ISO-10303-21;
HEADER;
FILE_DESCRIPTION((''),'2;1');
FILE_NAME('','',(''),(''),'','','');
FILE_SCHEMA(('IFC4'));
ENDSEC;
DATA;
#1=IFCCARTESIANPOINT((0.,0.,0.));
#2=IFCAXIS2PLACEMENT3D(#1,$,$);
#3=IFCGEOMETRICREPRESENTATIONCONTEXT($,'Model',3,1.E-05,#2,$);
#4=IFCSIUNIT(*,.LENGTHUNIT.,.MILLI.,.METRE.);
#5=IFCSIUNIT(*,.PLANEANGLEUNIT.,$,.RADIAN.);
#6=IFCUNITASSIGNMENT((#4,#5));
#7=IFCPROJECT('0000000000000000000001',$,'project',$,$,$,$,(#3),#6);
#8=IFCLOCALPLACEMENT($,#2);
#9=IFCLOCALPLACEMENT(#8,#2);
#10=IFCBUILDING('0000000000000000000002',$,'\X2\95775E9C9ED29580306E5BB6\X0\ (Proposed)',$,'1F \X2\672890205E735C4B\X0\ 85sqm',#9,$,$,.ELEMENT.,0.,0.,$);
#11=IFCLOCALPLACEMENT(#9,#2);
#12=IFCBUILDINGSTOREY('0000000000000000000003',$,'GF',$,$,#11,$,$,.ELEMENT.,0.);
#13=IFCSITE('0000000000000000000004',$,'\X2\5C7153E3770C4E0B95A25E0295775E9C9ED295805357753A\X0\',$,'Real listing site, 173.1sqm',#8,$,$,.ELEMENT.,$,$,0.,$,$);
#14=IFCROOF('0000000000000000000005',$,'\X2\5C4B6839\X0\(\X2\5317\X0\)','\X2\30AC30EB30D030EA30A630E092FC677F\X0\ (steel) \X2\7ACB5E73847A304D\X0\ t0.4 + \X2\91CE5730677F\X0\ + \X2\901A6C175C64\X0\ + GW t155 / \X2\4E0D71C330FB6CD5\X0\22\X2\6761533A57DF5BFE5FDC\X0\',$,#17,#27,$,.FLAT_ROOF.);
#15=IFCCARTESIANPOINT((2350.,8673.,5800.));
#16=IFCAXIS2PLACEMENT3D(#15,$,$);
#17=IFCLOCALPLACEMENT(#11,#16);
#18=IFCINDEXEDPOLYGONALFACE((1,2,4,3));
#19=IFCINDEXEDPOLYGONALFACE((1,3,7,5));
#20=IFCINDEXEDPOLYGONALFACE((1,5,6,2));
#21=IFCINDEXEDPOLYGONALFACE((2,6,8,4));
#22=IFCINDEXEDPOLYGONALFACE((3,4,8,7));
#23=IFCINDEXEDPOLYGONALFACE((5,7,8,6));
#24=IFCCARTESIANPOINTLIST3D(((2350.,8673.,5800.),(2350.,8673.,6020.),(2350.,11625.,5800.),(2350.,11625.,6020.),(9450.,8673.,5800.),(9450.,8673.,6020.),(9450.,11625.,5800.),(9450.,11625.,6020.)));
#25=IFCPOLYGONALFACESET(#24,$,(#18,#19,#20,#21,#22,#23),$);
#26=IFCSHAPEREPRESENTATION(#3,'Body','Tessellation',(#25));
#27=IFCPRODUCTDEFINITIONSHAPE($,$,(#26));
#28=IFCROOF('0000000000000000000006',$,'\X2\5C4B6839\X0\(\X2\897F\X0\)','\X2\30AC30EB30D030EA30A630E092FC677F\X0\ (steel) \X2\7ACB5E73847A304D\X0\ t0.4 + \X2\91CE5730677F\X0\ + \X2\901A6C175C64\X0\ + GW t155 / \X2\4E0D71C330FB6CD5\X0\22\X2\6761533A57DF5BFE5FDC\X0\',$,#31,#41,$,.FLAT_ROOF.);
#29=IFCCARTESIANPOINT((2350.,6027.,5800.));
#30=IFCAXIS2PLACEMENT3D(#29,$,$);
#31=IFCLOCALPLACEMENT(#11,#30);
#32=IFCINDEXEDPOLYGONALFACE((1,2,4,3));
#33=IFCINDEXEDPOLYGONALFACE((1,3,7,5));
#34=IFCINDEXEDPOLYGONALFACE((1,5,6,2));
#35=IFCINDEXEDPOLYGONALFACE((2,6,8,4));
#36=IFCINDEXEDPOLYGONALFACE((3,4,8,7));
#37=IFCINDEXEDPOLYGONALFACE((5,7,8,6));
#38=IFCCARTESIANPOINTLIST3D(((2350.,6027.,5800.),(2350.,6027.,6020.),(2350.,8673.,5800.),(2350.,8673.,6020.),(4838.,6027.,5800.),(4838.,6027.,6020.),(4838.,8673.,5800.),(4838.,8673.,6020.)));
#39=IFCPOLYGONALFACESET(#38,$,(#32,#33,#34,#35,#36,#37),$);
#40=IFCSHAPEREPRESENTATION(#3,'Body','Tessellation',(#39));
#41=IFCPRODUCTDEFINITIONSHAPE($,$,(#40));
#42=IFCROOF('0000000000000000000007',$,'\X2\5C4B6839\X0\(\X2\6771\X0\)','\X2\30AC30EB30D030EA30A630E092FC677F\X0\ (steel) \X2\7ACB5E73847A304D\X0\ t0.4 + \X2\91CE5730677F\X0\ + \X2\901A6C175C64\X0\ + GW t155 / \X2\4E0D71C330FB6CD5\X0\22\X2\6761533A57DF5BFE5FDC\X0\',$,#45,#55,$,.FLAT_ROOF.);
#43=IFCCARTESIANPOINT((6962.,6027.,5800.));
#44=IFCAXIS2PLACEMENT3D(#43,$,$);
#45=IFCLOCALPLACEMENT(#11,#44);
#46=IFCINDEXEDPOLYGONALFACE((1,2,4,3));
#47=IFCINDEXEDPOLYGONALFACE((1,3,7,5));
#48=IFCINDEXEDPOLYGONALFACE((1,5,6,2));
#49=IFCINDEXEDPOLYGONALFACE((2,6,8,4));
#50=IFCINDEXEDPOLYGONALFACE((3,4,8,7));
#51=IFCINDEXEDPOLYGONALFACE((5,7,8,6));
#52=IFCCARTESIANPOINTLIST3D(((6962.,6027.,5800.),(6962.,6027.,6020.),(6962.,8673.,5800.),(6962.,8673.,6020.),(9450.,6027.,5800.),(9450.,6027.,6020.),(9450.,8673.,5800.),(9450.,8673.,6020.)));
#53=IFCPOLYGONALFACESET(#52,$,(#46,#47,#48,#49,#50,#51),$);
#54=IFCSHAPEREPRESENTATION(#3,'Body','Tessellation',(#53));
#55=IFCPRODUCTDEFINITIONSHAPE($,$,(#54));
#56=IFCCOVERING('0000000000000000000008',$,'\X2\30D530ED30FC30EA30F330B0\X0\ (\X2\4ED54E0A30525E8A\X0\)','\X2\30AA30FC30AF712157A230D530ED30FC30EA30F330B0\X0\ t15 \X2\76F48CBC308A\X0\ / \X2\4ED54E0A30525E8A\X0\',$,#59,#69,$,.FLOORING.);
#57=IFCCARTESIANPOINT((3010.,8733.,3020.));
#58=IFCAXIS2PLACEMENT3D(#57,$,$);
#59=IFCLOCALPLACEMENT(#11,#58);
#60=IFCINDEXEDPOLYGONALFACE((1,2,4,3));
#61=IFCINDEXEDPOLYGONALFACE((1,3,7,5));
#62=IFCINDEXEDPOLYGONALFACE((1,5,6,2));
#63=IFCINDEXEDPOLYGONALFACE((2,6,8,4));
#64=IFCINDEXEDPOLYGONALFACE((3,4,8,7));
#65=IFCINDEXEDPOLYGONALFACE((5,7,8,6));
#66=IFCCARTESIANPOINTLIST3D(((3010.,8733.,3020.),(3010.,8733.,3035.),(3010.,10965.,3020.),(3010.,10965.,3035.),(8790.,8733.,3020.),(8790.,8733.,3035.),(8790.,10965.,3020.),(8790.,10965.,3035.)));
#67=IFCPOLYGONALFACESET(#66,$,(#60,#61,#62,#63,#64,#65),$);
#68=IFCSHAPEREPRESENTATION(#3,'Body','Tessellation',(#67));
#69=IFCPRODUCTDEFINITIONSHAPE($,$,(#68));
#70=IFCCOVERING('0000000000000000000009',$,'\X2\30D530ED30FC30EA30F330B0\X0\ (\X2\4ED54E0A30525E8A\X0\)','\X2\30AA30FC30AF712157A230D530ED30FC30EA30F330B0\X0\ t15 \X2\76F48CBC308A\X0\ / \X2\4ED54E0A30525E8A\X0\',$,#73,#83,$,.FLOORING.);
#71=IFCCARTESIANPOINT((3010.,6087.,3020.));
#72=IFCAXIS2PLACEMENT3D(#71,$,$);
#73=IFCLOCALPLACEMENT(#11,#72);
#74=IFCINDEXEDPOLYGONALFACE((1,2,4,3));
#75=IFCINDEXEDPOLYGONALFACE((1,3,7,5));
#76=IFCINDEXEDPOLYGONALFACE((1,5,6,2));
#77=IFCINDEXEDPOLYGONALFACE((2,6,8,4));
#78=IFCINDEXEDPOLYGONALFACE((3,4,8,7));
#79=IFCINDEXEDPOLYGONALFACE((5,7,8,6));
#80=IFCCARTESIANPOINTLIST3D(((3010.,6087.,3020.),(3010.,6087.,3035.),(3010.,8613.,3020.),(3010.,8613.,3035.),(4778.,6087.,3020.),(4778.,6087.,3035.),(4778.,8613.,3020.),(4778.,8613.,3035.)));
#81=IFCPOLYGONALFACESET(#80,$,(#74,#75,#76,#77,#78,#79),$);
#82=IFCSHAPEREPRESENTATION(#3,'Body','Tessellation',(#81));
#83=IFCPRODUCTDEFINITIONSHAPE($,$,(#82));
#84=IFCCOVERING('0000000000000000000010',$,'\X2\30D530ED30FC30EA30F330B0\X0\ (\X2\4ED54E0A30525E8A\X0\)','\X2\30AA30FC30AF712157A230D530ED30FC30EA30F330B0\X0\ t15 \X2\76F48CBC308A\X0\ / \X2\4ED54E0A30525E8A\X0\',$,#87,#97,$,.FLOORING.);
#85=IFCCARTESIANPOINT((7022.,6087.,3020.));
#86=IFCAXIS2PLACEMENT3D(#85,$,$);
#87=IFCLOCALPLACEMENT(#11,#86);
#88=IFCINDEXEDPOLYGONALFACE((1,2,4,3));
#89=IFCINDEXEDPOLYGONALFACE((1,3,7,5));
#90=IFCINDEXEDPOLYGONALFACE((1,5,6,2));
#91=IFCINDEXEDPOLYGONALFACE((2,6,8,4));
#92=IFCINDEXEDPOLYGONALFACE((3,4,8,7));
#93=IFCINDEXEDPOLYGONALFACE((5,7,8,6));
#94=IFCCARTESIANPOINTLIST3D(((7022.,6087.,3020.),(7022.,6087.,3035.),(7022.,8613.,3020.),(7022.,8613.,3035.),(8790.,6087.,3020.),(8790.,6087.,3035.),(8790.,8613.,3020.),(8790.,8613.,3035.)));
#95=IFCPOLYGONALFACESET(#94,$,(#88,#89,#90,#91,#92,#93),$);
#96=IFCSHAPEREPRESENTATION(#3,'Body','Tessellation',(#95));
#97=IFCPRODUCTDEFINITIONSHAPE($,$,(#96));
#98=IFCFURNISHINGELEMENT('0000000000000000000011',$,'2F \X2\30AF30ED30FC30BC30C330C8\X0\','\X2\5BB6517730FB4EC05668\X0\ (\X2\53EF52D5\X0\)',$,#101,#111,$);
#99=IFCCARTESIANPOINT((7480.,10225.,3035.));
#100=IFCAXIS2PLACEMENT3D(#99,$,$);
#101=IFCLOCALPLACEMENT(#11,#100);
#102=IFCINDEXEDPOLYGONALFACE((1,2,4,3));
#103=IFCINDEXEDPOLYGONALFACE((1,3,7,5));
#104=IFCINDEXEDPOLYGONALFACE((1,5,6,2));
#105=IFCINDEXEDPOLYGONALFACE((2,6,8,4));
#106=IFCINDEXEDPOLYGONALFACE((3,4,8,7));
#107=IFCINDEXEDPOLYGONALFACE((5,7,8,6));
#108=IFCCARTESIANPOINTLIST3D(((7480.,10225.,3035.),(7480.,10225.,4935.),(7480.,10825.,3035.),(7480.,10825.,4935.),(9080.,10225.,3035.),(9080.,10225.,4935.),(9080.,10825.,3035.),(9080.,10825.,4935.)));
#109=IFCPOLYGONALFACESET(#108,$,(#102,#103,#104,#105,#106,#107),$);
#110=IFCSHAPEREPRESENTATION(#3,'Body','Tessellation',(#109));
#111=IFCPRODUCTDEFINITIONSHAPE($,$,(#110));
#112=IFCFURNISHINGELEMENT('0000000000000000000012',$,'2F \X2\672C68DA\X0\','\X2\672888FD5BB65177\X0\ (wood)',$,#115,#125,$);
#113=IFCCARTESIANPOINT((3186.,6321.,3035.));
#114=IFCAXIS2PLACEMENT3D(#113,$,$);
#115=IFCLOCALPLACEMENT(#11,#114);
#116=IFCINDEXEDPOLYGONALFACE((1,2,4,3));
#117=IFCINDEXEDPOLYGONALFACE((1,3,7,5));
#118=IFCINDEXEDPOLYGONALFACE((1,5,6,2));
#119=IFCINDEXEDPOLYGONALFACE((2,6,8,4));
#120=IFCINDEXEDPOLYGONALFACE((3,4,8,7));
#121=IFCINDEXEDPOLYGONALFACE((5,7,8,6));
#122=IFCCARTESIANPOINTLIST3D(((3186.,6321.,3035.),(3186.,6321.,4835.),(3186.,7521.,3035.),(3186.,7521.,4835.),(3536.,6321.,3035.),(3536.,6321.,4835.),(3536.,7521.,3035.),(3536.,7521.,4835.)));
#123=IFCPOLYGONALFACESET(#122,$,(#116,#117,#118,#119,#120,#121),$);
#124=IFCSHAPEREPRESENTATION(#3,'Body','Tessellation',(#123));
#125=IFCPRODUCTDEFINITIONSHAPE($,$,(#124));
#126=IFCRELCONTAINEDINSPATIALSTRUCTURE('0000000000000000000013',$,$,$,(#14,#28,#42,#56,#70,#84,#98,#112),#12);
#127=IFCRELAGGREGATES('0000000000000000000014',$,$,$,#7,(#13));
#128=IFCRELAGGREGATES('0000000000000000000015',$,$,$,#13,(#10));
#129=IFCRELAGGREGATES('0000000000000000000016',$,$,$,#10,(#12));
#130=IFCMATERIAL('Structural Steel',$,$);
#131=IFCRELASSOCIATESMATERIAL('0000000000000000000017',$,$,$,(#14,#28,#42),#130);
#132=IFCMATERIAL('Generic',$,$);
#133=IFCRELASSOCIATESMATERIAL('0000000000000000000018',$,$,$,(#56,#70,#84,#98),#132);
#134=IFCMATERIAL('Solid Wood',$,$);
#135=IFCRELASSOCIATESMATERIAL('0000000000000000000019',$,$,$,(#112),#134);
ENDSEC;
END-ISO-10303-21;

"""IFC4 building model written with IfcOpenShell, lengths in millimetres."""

from ifc_helpers import new_model, si_unit, frame, frame_2d, origin, place, context, project, spatial, rectangle, extrude, material, element, save


model = new_model("IFC4")

# Units and contexts
model_context = context("Model", 3, precision=1e-05, world=origin())
ifc_project = project(units=[si_unit("LENGTHUNIT", "METRE", prefix="MILLI"), si_unit("PLANEANGLEUNIT", "RADIAN")], contexts=[model_context])

# Site, building, storey
site_placement = place(None, origin())
site = spatial("IfcSite", under=ifc_project, at=site_placement, Name="山口県下関市長府黒門南町", ObjectType="Real listing site, 173.1sqm", CompositionType="ELEMENT", RefElevation=0.0)
building_placement = place(site_placement, origin())
building = spatial("IfcBuilding", under=site, at=building_placement, Name="長府黒門の家 (Proposed)", ObjectType="1F 木造平屋 85sqm", CompositionType="ELEMENT", ElevationOfRefHeight=0.0, ElevationOfTerrain=0.0)
storey_placement = place(building_placement, origin())
storey = spatial("IfcBuildingStorey", under=building, at=storey_placement, Name="GF", CompositionType="ELEMENT", Elevation=0.0)

# Shared definitions
ifc_material_1 = material(Name="Solid Wood")

# Roofs
ifc_material_2 = material(Name="Structural Steel")
for number, where, name in (
    (1, (2350.0, 8673.0, 5800.0), "屋根(北)"),
):
    element("IfcRoof", number, at=place(storey_placement, frame(where)), inside=storey, material=ifc_material_2, Name=name, Description="ガルバリウム鋼板 (steel) 立平葺き t0.4 + 野地板 + 通気層 + GW t155 / 不燃・法22条区域対応", PredefinedType="FLAT_ROOF", context=model_context, shape_type="SweptSolid", body=[
        extrude(rectangle(XDim=7100.0, YDim=2952.0, at=frame_2d((3550.0, 1476.0))), frame((2350.0, 8673.0, 5800.0)), (0.0, 0.0, 1.0), 220.0),
    ])
roof_1_placement = place(storey_placement, frame((2350.0, 6027.0, 5800.0)))
element("IfcRoof", 2, at=roof_1_placement, inside=storey, material=ifc_material_2, Name="屋根(西)", Description="ガルバリウム鋼板 (steel) 立平葺き t0.4 + 野地板 + 通気層 + GW t155 / 不燃・法22条区域対応", PredefinedType="FLAT_ROOF", context=model_context, shape_type="SweptSolid", body=[
    extrude(rectangle(XDim=2488.0, YDim=2646.0, at=frame_2d((1244.0, 1323.0))), frame((2350.0, 6027.0, 5800.0)), (0.0, 0.0, 1.0), 220.0),
])
roof_2_placement = place(storey_placement, frame((6962.0, 6027.0, 5800.0)))
element("IfcRoof", 3, at=roof_2_placement, inside=storey, material=ifc_material_2, Name="屋根(東)", Description="ガルバリウム鋼板 (steel) 立平葺き t0.4 + 野地板 + 通気層 + GW t155 / 不燃・法22条区域対応", PredefinedType="FLAT_ROOF", context=model_context, shape_type="SweptSolid", body=[
    extrude(rectangle(XDim=2488.0, YDim=2646.0, at=frame_2d((1244.0, 1323.0))), frame((6962.0, 6027.0, 5800.0)), (0.0, 0.0, 1.0), 220.0),
])

# Coverings
ifc_material_3 = material(Name="Generic")
covering_1_placement = place(storey_placement, frame((3010.0, 8733.0, 3020.0)))
element("IfcCovering", 4, at=covering_1_placement, inside=storey, material=ifc_material_3, Name="フローリング (仕上げ床)", Description="オーク無垢フローリング t15 直貼り / 仕上げ床", PredefinedType="FLOORING", context=model_context, shape_type="SweptSolid", body=[
    extrude(rectangle(XDim=5780.0, YDim=2232.0, at=frame_2d((2890.0, 1116.0))), frame((3010.0, 8733.0, 3020.0)), (0.0, 0.0, 1.0), 15.0),
])
covering_2_placement = place(storey_placement, frame((3010.0, 6087.0, 3020.0)))
element("IfcCovering", 5, at=covering_2_placement, inside=storey, material=ifc_material_3, Name="フローリング (仕上げ床)", Description="オーク無垢フローリング t15 直貼り / 仕上げ床", PredefinedType="FLOORING", context=model_context, shape_type="SweptSolid", body=[
    extrude(rectangle(XDim=1768.0, YDim=2526.0, at=frame_2d((884.0, 1263.0))), frame((3010.0, 6087.0, 3020.0)), (0.0, 0.0, 1.0), 15.0),
])
covering_3_placement = place(storey_placement, frame((7022.0, 6087.0, 3020.0)))
element("IfcCovering", 6, at=covering_3_placement, inside=storey, material=ifc_material_3, Name="フローリング (仕上げ床)", Description="オーク無垢フローリング t15 直貼り / 仕上げ床", PredefinedType="FLOORING", context=model_context, shape_type="SweptSolid", body=[
    extrude(rectangle(XDim=1768.0, YDim=2526.0, at=frame_2d((884.0, 1263.0))), frame((7022.0, 6087.0, 3020.0)), (0.0, 0.0, 1.0), 15.0),
])

# Furnishing elements
furnishing_1_placement = place(storey_placement, frame((7480.0, 10225.0, 3035.0)))
element("IfcFurnishingElement", 7, at=furnishing_1_placement, inside=storey, material=ifc_material_3, Name="2F クローゼット", Description="家具・什器 (可動)", context=model_context, shape_type="SweptSolid", body=[
    extrude(rectangle(XDim=1600.0, YDim=600.0, at=frame_2d((800.0, 300.0))), frame((7480.0, 10225.0, 3035.0)), (0.0, 0.0, 1.0), 1900.0),
])
furnishing_2_placement = place(storey_placement, frame((3186.0, 6321.0, 3035.0)))
element("IfcFurnishingElement", 8, at=furnishing_2_placement, inside=storey, material=ifc_material_1, Name="2F 本棚", Description="木製家具 (wood)", context=model_context, shape_type="SweptSolid", body=[
    extrude(rectangle(XDim=350.0, YDim=1200.0, at=frame_2d((175.0, 600.0))), frame((3186.0, 6321.0, 3035.0)), (0.0, 0.0, 1.0), 1800.0),
])

save(model, "model.ifc")
